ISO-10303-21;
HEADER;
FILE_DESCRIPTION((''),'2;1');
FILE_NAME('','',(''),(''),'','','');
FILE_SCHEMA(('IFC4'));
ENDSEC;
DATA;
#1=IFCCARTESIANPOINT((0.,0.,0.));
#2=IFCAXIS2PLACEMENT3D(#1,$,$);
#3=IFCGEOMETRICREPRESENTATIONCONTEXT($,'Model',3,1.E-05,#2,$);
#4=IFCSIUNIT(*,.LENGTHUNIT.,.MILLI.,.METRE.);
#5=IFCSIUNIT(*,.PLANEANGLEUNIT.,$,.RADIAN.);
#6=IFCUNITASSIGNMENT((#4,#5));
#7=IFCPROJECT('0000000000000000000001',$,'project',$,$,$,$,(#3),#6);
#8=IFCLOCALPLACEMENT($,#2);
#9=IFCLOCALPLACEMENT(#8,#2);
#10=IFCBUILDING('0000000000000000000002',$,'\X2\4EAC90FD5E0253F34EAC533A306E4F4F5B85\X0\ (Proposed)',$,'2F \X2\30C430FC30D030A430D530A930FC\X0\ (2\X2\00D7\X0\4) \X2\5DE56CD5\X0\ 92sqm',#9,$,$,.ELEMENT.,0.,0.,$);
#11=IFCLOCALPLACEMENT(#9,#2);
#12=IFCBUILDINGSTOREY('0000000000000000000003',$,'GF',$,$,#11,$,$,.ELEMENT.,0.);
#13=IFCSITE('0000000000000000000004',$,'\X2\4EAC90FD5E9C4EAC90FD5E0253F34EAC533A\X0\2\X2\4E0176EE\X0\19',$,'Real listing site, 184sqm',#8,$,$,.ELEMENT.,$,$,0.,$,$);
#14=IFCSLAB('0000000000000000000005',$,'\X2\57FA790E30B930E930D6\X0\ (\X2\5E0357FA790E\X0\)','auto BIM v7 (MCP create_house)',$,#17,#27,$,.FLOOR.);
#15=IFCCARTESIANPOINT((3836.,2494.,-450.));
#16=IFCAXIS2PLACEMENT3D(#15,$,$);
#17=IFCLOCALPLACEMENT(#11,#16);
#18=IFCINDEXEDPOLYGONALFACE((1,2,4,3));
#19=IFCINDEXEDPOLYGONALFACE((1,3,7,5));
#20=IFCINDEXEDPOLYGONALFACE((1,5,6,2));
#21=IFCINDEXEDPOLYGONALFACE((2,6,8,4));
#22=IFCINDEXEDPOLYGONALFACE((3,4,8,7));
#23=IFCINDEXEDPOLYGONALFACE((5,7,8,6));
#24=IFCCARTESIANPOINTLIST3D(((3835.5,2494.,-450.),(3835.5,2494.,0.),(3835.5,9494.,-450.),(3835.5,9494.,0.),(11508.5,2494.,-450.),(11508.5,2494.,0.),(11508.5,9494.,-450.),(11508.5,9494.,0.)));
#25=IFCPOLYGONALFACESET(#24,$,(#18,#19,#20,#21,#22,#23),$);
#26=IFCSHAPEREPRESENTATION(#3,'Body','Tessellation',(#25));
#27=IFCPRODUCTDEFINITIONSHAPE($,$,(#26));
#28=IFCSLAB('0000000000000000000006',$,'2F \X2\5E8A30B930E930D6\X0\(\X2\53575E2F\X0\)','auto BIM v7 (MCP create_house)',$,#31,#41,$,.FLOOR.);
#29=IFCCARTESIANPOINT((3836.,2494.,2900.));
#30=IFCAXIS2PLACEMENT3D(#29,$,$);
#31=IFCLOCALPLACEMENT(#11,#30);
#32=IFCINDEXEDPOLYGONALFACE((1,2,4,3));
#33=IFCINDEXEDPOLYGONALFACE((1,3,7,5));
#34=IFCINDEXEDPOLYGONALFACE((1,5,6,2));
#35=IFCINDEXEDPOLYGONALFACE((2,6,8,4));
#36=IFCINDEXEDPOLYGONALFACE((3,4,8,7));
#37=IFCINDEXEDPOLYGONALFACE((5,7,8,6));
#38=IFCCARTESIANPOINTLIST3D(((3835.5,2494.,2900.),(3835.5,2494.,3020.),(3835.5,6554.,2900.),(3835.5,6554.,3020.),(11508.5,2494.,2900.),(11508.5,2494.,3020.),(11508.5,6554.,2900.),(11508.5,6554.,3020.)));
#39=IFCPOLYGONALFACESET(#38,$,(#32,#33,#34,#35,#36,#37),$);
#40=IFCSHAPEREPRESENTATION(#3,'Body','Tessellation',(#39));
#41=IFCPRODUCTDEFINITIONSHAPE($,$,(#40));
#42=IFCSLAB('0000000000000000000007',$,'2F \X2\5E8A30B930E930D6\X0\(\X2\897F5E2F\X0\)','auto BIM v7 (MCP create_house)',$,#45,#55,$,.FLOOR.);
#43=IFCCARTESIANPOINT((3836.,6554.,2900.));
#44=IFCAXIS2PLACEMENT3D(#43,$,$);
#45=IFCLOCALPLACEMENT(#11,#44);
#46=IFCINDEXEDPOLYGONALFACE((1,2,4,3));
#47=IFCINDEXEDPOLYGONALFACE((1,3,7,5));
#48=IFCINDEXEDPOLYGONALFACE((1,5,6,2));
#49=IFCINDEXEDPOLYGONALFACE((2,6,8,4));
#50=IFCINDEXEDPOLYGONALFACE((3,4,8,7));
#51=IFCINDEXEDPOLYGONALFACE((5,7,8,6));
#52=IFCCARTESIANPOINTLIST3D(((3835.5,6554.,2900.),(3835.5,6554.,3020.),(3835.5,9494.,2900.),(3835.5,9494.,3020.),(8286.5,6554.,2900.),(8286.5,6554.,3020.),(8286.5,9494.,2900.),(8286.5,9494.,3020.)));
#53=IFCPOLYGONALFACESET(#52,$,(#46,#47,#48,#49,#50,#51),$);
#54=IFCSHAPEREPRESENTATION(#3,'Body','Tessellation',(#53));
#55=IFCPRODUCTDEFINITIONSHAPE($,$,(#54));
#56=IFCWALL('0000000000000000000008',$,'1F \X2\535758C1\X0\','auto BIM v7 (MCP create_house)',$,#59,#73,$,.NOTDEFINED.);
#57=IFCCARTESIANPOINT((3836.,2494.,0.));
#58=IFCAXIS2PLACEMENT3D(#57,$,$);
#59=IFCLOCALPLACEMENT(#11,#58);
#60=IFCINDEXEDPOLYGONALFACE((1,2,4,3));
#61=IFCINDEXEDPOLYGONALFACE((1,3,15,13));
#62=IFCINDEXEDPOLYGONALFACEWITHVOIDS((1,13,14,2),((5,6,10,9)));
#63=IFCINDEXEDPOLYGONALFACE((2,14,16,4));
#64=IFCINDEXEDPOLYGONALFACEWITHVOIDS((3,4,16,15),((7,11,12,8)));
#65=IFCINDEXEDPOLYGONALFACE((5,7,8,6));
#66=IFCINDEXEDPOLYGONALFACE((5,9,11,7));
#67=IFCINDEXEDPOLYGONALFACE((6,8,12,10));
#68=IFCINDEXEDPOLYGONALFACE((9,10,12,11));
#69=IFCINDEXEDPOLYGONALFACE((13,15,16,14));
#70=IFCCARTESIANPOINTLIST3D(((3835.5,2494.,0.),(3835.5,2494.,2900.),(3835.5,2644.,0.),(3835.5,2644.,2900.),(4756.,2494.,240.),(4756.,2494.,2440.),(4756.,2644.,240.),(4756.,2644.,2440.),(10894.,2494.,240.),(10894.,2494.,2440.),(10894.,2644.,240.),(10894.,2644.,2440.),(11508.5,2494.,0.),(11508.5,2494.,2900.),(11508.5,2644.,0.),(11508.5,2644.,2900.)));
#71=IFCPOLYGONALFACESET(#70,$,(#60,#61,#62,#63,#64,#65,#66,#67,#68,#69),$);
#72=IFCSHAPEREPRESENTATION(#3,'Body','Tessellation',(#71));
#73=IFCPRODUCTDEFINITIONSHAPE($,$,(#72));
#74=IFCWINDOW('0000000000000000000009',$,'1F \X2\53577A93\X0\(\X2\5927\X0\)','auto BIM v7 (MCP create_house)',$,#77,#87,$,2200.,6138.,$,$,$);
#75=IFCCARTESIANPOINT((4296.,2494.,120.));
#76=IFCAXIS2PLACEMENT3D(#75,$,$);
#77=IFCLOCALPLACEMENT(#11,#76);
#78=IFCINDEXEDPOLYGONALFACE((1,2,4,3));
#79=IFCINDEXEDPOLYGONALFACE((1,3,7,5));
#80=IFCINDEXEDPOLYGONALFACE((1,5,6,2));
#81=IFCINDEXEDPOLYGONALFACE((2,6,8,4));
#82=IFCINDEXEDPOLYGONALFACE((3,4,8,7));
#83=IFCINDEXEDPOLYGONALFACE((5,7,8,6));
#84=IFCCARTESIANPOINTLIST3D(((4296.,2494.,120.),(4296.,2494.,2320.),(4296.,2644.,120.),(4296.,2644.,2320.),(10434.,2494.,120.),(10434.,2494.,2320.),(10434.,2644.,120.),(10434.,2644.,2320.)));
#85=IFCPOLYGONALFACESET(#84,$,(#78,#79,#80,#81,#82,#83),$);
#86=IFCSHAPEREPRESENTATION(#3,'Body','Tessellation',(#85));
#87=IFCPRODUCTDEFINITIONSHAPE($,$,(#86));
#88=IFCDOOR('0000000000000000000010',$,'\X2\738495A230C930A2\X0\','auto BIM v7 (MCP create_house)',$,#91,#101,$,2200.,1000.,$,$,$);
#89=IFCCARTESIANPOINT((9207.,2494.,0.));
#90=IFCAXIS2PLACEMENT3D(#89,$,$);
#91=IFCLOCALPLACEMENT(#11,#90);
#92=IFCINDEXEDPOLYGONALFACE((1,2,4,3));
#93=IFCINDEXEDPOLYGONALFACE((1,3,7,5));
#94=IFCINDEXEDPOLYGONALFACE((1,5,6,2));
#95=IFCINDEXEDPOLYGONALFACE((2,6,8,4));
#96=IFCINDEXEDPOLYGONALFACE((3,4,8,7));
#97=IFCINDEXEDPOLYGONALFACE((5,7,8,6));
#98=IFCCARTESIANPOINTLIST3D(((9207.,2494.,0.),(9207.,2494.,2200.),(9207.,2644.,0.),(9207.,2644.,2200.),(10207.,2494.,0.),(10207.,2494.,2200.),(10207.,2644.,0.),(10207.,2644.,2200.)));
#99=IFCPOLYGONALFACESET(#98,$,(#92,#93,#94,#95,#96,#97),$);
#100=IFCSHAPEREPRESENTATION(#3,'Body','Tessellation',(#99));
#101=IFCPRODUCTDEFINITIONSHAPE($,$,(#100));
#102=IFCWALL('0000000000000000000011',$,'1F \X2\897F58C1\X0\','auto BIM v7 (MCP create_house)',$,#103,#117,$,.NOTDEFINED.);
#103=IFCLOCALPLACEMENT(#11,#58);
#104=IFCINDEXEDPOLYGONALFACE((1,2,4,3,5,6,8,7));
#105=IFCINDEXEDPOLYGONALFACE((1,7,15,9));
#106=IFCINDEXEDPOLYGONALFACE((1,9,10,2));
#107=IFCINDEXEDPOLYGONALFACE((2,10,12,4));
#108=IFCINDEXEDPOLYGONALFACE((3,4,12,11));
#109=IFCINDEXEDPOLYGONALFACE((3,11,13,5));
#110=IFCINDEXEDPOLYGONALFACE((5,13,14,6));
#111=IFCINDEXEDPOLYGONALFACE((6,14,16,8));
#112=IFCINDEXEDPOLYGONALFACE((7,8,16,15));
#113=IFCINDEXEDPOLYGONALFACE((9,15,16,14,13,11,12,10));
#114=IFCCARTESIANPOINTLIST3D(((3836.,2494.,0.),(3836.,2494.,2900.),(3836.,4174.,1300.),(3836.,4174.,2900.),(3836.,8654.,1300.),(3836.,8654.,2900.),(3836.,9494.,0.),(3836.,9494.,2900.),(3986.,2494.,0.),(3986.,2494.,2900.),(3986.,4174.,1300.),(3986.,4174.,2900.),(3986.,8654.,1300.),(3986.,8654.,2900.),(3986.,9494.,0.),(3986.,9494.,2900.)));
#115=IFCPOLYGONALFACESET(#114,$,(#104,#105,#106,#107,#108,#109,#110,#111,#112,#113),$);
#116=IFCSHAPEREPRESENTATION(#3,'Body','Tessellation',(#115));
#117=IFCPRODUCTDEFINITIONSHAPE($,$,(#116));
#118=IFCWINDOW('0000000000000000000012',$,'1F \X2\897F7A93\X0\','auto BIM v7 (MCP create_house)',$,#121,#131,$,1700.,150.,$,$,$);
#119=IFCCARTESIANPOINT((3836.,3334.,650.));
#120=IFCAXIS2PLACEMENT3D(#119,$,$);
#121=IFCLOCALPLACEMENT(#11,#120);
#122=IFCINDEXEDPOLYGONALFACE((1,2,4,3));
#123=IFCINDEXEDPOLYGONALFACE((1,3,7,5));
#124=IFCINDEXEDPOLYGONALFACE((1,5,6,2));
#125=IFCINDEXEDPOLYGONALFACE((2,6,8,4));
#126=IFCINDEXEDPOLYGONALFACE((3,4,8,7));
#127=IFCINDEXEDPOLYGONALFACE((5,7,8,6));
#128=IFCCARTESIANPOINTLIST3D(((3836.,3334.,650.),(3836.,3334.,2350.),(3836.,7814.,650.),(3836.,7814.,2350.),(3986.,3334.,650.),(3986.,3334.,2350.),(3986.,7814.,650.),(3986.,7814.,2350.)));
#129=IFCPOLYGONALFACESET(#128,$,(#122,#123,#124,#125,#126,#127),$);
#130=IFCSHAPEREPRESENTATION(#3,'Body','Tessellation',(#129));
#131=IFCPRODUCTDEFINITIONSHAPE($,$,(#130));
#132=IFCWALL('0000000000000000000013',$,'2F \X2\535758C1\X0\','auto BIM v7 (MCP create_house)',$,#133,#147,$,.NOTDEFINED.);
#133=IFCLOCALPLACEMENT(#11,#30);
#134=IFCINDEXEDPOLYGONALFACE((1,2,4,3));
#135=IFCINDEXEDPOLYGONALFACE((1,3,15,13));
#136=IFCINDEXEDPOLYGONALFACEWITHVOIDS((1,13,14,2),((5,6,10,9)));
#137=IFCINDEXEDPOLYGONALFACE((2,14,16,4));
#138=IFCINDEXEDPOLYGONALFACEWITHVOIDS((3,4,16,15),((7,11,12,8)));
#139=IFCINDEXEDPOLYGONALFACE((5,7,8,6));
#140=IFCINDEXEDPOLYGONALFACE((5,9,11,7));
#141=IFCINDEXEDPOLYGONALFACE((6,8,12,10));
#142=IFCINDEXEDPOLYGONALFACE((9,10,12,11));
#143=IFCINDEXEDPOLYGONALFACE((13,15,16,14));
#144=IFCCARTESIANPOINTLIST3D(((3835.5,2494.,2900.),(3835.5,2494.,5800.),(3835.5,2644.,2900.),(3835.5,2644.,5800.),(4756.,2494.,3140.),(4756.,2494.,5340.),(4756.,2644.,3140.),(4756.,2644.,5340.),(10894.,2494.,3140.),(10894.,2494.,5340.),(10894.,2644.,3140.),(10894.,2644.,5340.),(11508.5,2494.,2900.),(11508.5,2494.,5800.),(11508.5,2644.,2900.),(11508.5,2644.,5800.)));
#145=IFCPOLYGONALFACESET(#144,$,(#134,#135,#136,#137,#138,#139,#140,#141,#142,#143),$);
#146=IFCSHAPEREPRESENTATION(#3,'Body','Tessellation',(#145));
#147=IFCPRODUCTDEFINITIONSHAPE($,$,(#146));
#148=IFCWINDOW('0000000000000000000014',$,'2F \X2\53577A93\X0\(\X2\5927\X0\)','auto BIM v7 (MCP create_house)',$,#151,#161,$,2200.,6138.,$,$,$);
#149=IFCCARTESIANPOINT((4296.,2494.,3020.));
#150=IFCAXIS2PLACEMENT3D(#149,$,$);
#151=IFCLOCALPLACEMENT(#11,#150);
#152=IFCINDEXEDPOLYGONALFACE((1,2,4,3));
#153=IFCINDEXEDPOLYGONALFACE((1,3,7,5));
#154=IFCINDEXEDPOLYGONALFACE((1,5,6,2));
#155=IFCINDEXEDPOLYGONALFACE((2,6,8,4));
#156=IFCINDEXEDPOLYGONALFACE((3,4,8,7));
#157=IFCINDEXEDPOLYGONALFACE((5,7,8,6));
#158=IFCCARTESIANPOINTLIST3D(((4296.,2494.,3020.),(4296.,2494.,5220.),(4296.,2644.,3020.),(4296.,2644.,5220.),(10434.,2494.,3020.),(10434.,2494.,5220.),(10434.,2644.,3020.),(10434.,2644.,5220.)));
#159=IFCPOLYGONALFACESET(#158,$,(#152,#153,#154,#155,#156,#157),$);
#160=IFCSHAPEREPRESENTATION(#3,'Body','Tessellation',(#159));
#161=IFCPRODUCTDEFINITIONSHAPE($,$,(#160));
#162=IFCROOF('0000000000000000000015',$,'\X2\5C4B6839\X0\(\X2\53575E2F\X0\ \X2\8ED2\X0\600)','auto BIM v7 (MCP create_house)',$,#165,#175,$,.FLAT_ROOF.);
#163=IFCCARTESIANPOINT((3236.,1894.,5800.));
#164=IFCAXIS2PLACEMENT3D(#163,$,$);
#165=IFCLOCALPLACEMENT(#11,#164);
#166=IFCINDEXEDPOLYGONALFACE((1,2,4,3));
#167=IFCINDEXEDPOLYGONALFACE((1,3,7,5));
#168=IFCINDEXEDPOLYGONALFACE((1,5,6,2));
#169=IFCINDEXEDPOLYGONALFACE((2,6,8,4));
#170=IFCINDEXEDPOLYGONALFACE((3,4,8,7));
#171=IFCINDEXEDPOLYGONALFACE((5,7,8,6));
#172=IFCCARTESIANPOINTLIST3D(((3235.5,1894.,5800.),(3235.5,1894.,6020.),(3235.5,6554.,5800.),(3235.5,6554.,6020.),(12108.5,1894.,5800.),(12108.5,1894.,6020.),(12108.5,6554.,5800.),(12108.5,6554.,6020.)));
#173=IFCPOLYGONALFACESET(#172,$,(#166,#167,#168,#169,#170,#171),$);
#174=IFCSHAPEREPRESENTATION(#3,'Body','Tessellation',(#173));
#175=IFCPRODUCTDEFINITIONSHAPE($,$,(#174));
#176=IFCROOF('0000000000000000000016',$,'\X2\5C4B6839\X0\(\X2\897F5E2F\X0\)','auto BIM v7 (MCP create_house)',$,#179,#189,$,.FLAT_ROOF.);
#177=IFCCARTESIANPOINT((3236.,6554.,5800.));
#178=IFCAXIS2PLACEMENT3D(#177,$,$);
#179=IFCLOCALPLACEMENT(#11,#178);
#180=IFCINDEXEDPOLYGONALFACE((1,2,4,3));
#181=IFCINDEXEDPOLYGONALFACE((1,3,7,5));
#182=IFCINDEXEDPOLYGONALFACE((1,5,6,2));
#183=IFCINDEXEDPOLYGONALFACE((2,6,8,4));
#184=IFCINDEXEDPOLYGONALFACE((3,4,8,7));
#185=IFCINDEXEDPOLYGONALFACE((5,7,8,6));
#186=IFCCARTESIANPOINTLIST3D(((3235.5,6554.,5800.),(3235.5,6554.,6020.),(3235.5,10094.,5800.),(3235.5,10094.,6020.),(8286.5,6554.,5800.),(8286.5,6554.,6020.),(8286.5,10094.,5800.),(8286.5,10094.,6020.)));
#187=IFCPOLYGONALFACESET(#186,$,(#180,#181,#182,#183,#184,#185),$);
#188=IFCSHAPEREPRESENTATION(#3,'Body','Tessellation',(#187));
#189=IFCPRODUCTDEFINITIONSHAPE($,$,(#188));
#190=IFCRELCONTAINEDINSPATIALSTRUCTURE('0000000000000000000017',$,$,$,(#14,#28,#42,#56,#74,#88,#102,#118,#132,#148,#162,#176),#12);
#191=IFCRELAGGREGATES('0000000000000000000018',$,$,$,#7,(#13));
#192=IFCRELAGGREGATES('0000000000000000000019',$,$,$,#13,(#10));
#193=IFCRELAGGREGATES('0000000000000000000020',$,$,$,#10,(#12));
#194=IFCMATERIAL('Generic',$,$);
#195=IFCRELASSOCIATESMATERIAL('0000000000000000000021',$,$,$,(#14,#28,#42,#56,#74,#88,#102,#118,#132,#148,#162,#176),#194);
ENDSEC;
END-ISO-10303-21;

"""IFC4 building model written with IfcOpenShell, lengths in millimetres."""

from ifc_helpers import new_model, si_unit, frame, frame_2d, origin, place, context, project, spatial, rectangle, extrude, material, element, fill, save


model = new_model("IFC4")

# Units and contexts
model_context = context("Model", 3, precision=1e-05, world=origin())
ifc_project = project(units=[si_unit("LENGTHUNIT", "METRE", prefix="MILLI"), si_unit("PLANEANGLEUNIT", "RADIAN")], contexts=[model_context])

# Site, building, storey
site_placement = place(None, origin())
site = spatial("IfcSite", under=ifc_project, at=site_placement, Name="京都府京都市右京区2丁目19", ObjectType="Real listing site, 184sqm", CompositionType="ELEMENT", RefElevation=0.0)
building_placement = place(site_placement, origin())
building = spatial("IfcBuilding", under=site, at=building_placement, Name="京都市右京区の住宅 (Proposed)", ObjectType="2F ツーバイフォー (2×4) 工法 92sqm", CompositionType="ELEMENT", ElevationOfRefHeight=0.0, ElevationOfTerrain=0.0)
storey_placement = place(building_placement, origin())
storey = spatial("IfcBuildingStorey", under=building, at=storey_placement, Name="GF", CompositionType="ELEMENT", Elevation=0.0)

# Slabs
ifc_material = material(Name="Generic")
slab_1_placement = place(storey_placement, frame((3836.0, 2494.0, -450.0)))
element("IfcSlab", 1, at=slab_1_placement, inside=storey, material=ifc_material, Name="基礎スラブ (布基礎)", Description="auto BIM v7 (MCP create_house)", PredefinedType="FLOOR", context=model_context, shape_type="SweptSolid", body=[
    extrude(rectangle(XDim=7673.0, YDim=7000.0, at=frame_2d((3836.0, 3500.0))), frame((3836.0, 2494.0, -450.0)), (0.0, 0.0, 1.0), 450.0),
])
slab_2_placement = place(storey_placement, frame((3836.0, 2494.0, 2900.0)))
element("IfcSlab", 2, at=slab_2_placement, inside=storey, material=ifc_material, Name="2F 床スラブ(南帯)", Description="auto BIM v7 (MCP create_house)", PredefinedType="FLOOR", context=model_context, shape_type="SweptSolid", body=[
    extrude(rectangle(XDim=7673.0, YDim=4060.0, at=frame_2d((3836.0, 2030.0))), frame((3836.0, 2494.0, 2900.0)), (0.0, 0.0, 1.0), 120.0),
])
slab_3_placement = place(storey_placement, frame((3836.0, 6554.0, 2900.0)))
element("IfcSlab", 3, at=slab_3_placement, inside=storey, material=ifc_material, Name="2F 床スラブ(西帯)", Description="auto BIM v7 (MCP create_house)", PredefinedType="FLOOR", context=model_context, shape_type="SweptSolid", body=[
    extrude(rectangle(XDim=4451.0, YDim=2940.0, at=frame_2d((2225.0, 1470.0))), frame((3836.0, 6554.0, 2900.0)), (0.0, 0.0, 1.0), 120.0),
])

# Wall, openings, window, door
wall_1_placement = place(storey_placement, frame((3836.0, 2494.0, 0.0)))
wall_1 = element("IfcWall", 4, at=wall_1_placement, inside=storey, material=ifc_material, Name="1F 南壁", Description="auto BIM v7 (MCP create_house)", PredefinedType="NOTDEFINED", context=model_context, shape_type="SweptSolid", body=[
    extrude(rectangle(XDim=7673.0, YDim=150.0, at=frame_2d((3836.0, 75.0))), frame((3836.0, 2494.0, 0.0)), (0.0, 0.0, 1.0), 2900.0),
])
opening_1_placement = place(storey_placement, frame((4296.0, 2494.0, 120.0)))
opening_1 = element("IfcOpeningElement", 5, at=opening_1_placement, cuts=wall_1, PredefinedType="NOTDEFINED", context=model_context, shape_type="SweptSolid", body=[
    extrude(rectangle(XDim=6138.0, YDim=150.0, at=frame_2d((3069.0, 75.0))), frame((4296.0, 2494.0, 120.0)), (0.0, 0.0, 1.0), 2200.0),
])
opening_2_placement = place(storey_placement, frame((9207.0, 2494.0, 0.0)))
opening_2 = element("IfcOpeningElement", 6, at=opening_2_placement, cuts=wall_1, PredefinedType="NOTDEFINED", context=model_context, shape_type="SweptSolid", body=[
    extrude(rectangle(XDim=1000.0, YDim=150.0, at=frame_2d((500.0, 75.0))), frame((9207.0, 2494.0, 0.0)), (0.0, 0.0, 1.0), 2200.0),
])
window_1_placement = place(storey_placement, frame((4296.0, 2494.0, 120.0)))
window_1 = element("IfcWindow", 7, at=window_1_placement, inside=storey, material=ifc_material, Name="1F 南窓(大)", Description="auto BIM v7 (MCP create_house)", OverallHeight=2200.0, OverallWidth=6138.0, context=model_context, shape_type="SweptSolid", body=[
    extrude(rectangle(XDim=6138.0, YDim=150.0, at=frame_2d((3069.0, 75.0))), frame((4296.0, 2494.0, 120.0)), (0.0, 0.0, 1.0), 2200.0),
])
fill(opening_1, window_1)
door_placement = place(storey_placement, frame((9207.0, 2494.0, 0.0)))
door = element("IfcDoor", 8, at=door_placement, inside=storey, material=ifc_material, Name="玄関ドア", Description="auto BIM v7 (MCP create_house)", OverallHeight=2200.0, OverallWidth=1000.0, context=model_context, shape_type="SweptSolid", body=[
    extrude(rectangle(XDim=1000.0, YDim=150.0, at=frame_2d((500.0, 75.0))), frame((9207.0, 2494.0, 0.0)), (0.0, 0.0, 1.0), 2200.0),
])
fill(opening_2, door)

# Wall, opening, window
wall_2_placement = place(storey_placement, frame((3836.0, 2494.0, 0.0)))
wall_2 = element("IfcWall", 9, at=wall_2_placement, inside=storey, material=ifc_material, Name="1F 西壁", Description="auto BIM v7 (MCP create_house)", PredefinedType="NOTDEFINED", context=model_context, shape_type="SweptSolid", body=[
    extrude(rectangle(XDim=150.0, YDim=7000.0, at=frame_2d((75.0, 3500.0))), frame((3836.0, 2494.0, 0.0)), (0.0, 0.0, 1.0), 2900.0),
])
opening_3_placement = place(storey_placement, frame((3836.0, 3334.0, 650.0)))
opening_3 = element("IfcOpeningElement", 10, at=opening_3_placement, cuts=wall_2, PredefinedType="NOTDEFINED", context=model_context, shape_type="SweptSolid", body=[
    extrude(rectangle(XDim=150.0, YDim=4480.0, at=frame_2d((75.0, 2240.0))), frame((3836.0, 3334.0, 650.0)), (0.0, 0.0, 1.0), 1700.0),
])
window_2_placement = place(storey_placement, frame((3836.0, 3334.0, 650.0)))
window_2 = element("IfcWindow", 11, at=window_2_placement, inside=storey, material=ifc_material, Name="1F 西窓", Description="auto BIM v7 (MCP create_house)", OverallHeight=1700.0, OverallWidth=150.0, context=model_context, shape_type="SweptSolid", body=[
    extrude(rectangle(XDim=150.0, YDim=4480.0, at=frame_2d((75.0, 2240.0))), frame((3836.0, 3334.0, 650.0)), (0.0, 0.0, 1.0), 1700.0),
])
fill(opening_3, window_2)

# Wall, opening, window
wall_3_placement = place(storey_placement, frame((3836.0, 2494.0, 2900.0)))
wall_3 = element("IfcWall", 12, at=wall_3_placement, inside=storey, material=ifc_material, Name="2F 南壁", Description="auto BIM v7 (MCP create_house)", PredefinedType="NOTDEFINED", context=model_context, shape_type="SweptSolid", body=[
    extrude(rectangle(XDim=7673.0, YDim=150.0, at=frame_2d((3836.0, 75.0))), frame((3836.0, 2494.0, 2900.0)), (0.0, 0.0, 1.0), 2900.0),
])
opening_4_placement = place(storey_placement, frame((4296.0, 2494.0, 3020.0)))
opening_4 = element("IfcOpeningElement", 13, at=opening_4_placement, cuts=wall_3, PredefinedType="NOTDEFINED", context=model_context, shape_type="SweptSolid", body=[
    extrude(rectangle(XDim=6138.0, YDim=150.0, at=frame_2d((3069.0, 75.0))), frame((4296.0, 2494.0, 3020.0)), (0.0, 0.0, 1.0), 2200.0),
])
window_3_placement = place(storey_placement, frame((4296.0, 2494.0, 3020.0)))
window_3 = element("IfcWindow", 14, at=window_3_placement, inside=storey, material=ifc_material, Name="2F 南窓(大)", Description="auto BIM v7 (MCP create_house)", OverallHeight=2200.0, OverallWidth=6138.0, context=model_context, shape_type="SweptSolid", body=[
    extrude(rectangle(XDim=6138.0, YDim=150.0, at=frame_2d((3069.0, 75.0))), frame((4296.0, 2494.0, 3020.0)), (0.0, 0.0, 1.0), 2200.0),
])
fill(opening_4, window_3)

# Roofs
roof_1_placement = place(storey_placement, frame((3236.0, 1894.0, 5800.0)))
element("IfcRoof", 15, at=roof_1_placement, inside=storey, material=ifc_material, Name="屋根(南帯 軒600)", Description="auto BIM v7 (MCP create_house)", PredefinedType="FLAT_ROOF", context=model_context, shape_type="SweptSolid", body=[
    extrude(rectangle(XDim=8873.0, YDim=4660.0, at=frame_2d((4436.0, 2330.0))), frame((3236.0, 1894.0, 5800.0)), (0.0, 0.0, 1.0), 220.0),
])
roof_2_placement = place(storey_placement, frame((3236.0, 6554.0, 5800.0)))
element("IfcRoof", 16, at=roof_2_placement, inside=storey, material=ifc_material, Name="屋根(西帯)", Description="auto BIM v7 (MCP create_house)", PredefinedType="FLAT_ROOF", context=model_context, shape_type="SweptSolid", body=[
    extrude(rectangle(XDim=5051.0, YDim=3540.0, at=frame_2d((2525.0, 1770.0))), frame((3236.0, 6554.0, 5800.0)), (0.0, 0.0, 1.0), 220.0),
])

save(model, "model.ifc")
